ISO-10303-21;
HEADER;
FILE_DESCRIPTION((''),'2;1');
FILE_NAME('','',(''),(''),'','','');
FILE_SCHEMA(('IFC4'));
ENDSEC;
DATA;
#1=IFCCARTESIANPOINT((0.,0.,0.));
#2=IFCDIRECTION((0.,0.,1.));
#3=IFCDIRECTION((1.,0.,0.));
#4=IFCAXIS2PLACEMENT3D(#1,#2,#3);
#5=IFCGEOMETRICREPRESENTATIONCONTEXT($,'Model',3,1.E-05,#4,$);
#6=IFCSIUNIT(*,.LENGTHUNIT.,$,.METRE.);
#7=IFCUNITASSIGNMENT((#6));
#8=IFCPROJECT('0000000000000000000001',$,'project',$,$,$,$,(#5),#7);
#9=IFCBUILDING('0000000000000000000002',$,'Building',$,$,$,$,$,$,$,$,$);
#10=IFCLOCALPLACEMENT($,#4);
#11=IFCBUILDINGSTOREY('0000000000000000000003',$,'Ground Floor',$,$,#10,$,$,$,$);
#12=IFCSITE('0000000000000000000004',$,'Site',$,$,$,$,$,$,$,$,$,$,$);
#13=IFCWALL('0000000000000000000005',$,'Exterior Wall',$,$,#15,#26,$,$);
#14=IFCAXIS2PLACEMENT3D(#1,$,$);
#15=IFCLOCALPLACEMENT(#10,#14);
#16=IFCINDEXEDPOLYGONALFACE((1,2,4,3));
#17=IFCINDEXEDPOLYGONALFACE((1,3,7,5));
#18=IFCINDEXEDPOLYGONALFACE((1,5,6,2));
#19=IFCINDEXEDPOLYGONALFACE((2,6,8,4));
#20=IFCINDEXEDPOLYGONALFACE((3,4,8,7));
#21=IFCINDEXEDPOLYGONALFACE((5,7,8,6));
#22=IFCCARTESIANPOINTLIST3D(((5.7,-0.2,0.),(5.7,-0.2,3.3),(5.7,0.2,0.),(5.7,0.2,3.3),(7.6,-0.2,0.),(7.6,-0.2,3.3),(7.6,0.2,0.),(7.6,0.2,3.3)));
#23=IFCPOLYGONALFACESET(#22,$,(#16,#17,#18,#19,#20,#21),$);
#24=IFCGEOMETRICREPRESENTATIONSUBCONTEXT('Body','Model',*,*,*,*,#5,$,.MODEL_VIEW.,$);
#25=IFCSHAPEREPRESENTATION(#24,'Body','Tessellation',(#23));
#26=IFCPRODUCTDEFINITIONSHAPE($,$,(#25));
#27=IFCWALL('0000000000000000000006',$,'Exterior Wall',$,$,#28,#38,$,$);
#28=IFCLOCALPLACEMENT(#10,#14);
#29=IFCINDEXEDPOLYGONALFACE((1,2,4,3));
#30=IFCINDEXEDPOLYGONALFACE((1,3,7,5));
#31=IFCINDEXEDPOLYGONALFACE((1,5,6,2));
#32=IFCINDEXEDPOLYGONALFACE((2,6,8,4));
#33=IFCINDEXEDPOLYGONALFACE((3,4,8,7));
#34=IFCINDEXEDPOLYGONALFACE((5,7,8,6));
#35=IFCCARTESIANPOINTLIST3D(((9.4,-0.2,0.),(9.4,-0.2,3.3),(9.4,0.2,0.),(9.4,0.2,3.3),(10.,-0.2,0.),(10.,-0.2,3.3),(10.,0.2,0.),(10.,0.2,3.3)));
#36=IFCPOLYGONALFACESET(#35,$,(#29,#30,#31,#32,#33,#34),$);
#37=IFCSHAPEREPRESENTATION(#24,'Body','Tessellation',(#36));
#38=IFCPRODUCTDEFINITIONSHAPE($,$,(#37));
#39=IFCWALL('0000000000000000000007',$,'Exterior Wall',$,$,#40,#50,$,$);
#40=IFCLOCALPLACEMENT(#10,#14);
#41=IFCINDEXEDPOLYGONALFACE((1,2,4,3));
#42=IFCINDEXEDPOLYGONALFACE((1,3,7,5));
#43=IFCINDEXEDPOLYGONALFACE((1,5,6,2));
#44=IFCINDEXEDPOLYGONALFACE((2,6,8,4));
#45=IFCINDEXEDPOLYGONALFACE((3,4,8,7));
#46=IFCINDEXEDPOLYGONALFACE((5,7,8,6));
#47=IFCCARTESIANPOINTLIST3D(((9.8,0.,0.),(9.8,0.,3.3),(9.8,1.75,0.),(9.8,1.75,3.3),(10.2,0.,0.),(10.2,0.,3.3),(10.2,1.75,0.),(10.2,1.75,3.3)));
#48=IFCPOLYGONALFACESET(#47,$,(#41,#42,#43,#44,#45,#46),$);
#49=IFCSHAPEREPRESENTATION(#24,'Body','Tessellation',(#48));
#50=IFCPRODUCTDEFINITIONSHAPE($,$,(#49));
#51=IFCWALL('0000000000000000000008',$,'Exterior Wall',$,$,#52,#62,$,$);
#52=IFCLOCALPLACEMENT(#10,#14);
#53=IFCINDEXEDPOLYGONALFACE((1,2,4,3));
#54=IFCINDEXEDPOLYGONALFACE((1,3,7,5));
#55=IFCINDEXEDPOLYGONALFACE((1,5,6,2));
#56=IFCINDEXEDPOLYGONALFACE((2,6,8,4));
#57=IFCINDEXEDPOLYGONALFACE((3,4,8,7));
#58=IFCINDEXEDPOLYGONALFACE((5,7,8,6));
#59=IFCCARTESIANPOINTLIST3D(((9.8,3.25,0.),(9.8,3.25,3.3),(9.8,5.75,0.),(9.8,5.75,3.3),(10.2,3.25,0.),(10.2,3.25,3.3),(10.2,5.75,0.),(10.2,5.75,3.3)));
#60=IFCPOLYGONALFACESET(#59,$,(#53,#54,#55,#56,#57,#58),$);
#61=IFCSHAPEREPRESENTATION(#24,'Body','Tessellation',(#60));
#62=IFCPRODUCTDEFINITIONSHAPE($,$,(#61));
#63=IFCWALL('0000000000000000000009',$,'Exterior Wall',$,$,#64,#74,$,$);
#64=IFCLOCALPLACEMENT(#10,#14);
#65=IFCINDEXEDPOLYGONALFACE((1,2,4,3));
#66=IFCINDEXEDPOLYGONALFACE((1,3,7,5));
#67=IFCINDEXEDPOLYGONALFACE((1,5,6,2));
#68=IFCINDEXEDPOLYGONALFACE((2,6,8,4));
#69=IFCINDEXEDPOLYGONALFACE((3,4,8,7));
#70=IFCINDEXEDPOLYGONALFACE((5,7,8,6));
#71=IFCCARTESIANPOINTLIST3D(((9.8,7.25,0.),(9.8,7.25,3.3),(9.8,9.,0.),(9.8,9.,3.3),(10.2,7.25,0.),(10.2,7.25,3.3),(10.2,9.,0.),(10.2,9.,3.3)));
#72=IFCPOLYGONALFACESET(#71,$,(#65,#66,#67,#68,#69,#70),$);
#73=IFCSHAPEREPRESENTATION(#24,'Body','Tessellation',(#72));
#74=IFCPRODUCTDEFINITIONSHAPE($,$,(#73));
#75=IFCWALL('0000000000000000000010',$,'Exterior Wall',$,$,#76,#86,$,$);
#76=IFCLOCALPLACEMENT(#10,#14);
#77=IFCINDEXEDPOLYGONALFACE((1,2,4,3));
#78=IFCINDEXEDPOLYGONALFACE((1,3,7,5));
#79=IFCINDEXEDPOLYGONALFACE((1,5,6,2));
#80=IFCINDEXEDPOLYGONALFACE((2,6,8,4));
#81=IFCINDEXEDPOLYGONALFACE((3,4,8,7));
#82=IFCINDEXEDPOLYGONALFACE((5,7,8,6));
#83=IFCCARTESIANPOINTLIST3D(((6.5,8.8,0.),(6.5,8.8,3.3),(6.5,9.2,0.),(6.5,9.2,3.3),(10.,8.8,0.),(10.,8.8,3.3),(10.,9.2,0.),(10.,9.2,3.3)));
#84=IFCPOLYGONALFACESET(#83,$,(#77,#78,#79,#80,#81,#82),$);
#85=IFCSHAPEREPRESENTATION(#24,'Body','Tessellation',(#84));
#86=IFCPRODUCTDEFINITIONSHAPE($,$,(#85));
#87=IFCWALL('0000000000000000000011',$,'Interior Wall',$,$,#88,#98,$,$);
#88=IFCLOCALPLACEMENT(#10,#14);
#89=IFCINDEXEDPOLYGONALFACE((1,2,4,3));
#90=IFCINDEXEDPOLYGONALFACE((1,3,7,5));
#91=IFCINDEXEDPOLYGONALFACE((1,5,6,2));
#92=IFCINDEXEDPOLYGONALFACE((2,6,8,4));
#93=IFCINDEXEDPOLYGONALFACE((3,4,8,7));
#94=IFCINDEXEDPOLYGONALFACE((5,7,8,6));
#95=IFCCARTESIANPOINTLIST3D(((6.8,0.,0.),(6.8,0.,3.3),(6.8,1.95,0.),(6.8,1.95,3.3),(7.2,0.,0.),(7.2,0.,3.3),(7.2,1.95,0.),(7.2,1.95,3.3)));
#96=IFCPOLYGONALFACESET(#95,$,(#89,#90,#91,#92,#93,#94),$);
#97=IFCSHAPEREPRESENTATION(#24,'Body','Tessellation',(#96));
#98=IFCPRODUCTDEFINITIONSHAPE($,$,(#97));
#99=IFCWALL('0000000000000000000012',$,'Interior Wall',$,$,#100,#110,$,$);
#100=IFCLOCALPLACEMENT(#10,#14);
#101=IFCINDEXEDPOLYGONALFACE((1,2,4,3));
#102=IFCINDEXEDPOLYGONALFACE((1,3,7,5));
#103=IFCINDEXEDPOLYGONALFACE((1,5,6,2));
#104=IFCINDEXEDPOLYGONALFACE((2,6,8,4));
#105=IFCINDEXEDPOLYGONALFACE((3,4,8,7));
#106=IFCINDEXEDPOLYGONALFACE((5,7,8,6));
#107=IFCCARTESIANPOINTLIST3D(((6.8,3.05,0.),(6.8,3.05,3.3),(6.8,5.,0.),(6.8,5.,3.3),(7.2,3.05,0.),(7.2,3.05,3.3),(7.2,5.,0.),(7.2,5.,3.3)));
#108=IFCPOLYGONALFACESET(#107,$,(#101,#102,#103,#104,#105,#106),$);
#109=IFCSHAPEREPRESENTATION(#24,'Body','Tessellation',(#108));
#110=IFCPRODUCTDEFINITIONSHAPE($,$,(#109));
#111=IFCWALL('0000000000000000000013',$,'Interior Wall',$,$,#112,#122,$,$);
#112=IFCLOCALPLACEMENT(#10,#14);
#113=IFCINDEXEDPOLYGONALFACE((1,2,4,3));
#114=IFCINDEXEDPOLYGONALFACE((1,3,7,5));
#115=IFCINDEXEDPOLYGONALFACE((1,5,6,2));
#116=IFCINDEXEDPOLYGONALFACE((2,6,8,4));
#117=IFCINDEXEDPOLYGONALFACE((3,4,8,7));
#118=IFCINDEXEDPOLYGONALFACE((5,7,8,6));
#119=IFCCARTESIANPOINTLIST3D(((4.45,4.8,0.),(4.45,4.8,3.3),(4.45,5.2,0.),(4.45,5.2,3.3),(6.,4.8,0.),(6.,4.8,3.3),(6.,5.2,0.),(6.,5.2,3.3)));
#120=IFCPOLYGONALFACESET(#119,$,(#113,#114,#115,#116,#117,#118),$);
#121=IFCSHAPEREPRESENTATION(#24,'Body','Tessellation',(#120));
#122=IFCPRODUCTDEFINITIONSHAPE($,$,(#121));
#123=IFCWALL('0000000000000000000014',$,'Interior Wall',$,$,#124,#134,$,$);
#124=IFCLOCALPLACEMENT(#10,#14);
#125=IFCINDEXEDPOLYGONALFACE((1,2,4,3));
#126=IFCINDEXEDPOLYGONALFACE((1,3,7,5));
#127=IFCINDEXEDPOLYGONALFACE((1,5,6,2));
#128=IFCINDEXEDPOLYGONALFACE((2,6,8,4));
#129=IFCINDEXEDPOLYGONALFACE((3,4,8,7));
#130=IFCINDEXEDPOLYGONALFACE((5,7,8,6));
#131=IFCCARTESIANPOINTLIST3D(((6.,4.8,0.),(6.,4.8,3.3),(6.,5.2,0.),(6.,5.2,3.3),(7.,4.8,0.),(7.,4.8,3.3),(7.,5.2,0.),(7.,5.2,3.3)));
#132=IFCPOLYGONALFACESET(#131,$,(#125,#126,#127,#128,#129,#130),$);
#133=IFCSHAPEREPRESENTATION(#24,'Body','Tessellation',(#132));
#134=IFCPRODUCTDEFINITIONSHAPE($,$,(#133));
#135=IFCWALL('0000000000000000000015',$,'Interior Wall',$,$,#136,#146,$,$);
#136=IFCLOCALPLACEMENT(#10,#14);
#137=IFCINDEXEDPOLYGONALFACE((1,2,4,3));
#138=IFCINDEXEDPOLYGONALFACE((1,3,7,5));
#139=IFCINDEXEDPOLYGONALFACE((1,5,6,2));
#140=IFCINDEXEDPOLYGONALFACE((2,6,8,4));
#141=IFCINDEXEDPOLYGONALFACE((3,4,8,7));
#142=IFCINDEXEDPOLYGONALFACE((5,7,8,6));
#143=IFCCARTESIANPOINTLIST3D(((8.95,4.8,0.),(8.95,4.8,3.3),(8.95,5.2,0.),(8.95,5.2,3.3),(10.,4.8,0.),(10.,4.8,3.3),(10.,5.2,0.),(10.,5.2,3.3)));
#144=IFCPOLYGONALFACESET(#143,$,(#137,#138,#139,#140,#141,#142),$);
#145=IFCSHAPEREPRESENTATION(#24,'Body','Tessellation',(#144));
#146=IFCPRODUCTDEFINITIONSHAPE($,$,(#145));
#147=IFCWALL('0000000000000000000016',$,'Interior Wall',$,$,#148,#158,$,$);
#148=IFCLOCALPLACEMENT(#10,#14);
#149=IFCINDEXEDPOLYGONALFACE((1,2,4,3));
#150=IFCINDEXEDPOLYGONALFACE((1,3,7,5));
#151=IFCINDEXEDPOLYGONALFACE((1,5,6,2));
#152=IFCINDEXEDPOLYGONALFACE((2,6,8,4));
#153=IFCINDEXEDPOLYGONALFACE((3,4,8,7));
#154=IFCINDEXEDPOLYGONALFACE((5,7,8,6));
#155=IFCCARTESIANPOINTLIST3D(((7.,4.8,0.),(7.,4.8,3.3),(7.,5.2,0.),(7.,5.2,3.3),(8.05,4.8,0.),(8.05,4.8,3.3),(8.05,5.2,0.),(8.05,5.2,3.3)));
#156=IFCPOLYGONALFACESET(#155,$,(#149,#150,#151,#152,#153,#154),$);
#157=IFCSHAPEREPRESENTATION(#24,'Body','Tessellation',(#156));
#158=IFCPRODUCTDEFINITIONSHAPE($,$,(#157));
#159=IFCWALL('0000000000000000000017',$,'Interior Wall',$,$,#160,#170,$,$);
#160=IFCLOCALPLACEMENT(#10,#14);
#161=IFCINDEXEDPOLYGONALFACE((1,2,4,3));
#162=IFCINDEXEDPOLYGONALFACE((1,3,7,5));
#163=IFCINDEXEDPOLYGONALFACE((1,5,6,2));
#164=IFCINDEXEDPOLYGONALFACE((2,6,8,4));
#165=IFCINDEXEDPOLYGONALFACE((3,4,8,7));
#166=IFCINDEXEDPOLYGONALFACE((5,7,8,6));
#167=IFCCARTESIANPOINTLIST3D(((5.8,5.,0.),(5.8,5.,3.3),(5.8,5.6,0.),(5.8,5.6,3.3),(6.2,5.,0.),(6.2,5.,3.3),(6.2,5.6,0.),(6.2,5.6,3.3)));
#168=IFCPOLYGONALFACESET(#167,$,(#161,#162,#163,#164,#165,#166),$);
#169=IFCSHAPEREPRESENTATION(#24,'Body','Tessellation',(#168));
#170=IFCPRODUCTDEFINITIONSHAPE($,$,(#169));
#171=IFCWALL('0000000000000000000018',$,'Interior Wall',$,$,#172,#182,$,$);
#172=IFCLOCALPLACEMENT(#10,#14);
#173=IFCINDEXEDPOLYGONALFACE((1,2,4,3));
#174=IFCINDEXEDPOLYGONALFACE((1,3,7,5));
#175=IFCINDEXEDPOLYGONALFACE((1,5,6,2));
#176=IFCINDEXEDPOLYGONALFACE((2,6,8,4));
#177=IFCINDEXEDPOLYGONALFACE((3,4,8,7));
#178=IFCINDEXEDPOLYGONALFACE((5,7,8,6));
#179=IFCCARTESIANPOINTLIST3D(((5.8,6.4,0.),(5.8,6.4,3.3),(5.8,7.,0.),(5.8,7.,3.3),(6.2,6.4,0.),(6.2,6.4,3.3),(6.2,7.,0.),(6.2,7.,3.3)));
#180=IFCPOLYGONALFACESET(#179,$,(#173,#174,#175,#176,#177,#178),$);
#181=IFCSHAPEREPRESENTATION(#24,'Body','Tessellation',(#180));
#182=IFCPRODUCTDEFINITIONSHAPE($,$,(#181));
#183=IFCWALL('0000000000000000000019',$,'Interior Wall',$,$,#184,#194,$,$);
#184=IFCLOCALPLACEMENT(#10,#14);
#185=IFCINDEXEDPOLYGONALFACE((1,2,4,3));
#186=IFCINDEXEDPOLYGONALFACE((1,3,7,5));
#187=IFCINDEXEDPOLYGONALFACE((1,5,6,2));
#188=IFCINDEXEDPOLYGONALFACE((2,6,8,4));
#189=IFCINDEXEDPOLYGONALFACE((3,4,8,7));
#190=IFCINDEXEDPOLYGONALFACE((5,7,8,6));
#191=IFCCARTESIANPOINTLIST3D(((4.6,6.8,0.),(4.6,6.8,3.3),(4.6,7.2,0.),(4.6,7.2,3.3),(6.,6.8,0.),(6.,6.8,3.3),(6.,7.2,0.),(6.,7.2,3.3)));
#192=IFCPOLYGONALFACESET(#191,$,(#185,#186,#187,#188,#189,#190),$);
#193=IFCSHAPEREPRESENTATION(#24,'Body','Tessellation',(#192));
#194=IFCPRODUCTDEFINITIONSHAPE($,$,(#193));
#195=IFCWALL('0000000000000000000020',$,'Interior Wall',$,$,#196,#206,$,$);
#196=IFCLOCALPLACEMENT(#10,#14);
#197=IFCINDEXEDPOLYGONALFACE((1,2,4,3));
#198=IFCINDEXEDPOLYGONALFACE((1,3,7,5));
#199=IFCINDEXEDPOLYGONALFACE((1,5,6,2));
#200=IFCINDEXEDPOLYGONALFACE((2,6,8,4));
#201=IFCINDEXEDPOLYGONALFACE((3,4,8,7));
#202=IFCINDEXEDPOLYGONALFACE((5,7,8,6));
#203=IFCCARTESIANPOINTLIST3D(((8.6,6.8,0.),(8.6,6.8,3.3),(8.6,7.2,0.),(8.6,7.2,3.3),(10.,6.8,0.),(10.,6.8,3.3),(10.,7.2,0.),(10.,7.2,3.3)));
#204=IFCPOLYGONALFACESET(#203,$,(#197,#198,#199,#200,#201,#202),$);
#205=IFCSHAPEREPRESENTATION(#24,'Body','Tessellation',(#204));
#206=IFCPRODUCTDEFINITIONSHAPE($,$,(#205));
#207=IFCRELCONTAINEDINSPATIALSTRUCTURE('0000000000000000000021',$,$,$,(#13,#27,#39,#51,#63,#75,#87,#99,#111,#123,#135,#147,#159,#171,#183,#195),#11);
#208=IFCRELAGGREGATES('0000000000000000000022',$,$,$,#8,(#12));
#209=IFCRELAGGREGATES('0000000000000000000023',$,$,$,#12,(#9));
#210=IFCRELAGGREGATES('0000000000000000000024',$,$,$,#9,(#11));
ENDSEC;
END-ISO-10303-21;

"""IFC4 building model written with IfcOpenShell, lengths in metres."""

from ifc_helpers import new_model, si_unit, frame, origin_with_axes, place, context, subcontext, project, spatial, indexed_curve, outline, extrude, element, save


model = new_model("IFC4")

# Units and contexts
model_context = context("Model", 3, precision=1e-05, world=origin_with_axes())
body_context = subcontext(model_context, "Body", "Model", "MODEL_VIEW")
ifc_project = project(units=[si_unit("LENGTHUNIT", "METRE")], contexts=[model_context])

# Site, building, storey
site = spatial("IfcSite", under=ifc_project, Name="Site")
building = spatial("IfcBuilding", under=site, Name="Building")
storey_placement = place(None, origin_with_axes())
storey = spatial("IfcBuildingStorey", under=building, at=storey_placement, Name="Ground Floor")

# Walls
wall_1_placement = place(storey_placement, frame((5.7, 0.0, 0.0), z_axis=(0.0, 0.0, 1.0), x_axis=(1.0, 0.0, 0.0)))
element("IfcWall", 1, at=wall_1_placement, inside=storey, Name="Exterior Wall", context=body_context, shape_type="SweptSolid", body=[
    extrude(outline(indexed_curve([(0.0, 0.0), (0.0, 0.4), (1.9, 0.4), (1.9, 0.0), (0.0, 0.0)], self_intersect=False)), frame((0.0, -0.2, 0.0), z_axis=(0.0, 0.0, 1.0), x_axis=(1.0, 0.0, 0.0)), (0.0, 0.0, 1.0), 3.3),
])
wall_2_placement = place(storey_placement, frame((9.4, 0.0, 0.0), z_axis=(0.0, 0.0, 1.0), x_axis=(1.0, 0.0, 0.0)))
element("IfcWall", 2, at=wall_2_placement, inside=storey, Name="Exterior Wall", context=body_context, shape_type="SweptSolid", body=[
    extrude(outline(indexed_curve([(0.0, 0.0), (0.0, 0.4), (0.6, 0.4), (0.6, 0.0), (0.0, 0.0)], self_intersect=False)), frame((0.0, -0.2, 0.0), z_axis=(0.0, 0.0, 1.0), x_axis=(1.0, 0.0, 0.0)), (0.0, 0.0, 1.0), 3.3),
])
wall_3_placement = place(storey_placement, frame((10.0, 0.0, 0.0), z_axis=(0.0, 0.0, 1.0), x_axis=(0.0, 1.0, 0.0)))
element("IfcWall", 3, at=wall_3_placement, inside=storey, Name="Exterior Wall", context=body_context, shape_type="SweptSolid", body=[
    extrude(outline(indexed_curve([(0.0, 0.0), (0.0, 0.4), (1.75, 0.4), (1.75, 0.0), (0.0, 0.0)], self_intersect=False)), frame((0.0, -0.2, 0.0), z_axis=(0.0, 0.0, 1.0), x_axis=(1.0, 0.0, 0.0)), (0.0, 0.0, 1.0), 3.3),
])
wall_4_placement = place(storey_placement, frame((10.0, 3.25, 0.0), z_axis=(0.0, 0.0, 1.0), x_axis=(0.0, 1.0, 0.0)))
element("IfcWall", 4, at=wall_4_placement, inside=storey, Name="Exterior Wall", context=body_context, shape_type="SweptSolid", body=[
    extrude(outline(indexed_curve([(0.0, 0.0), (0.0, 0.4), (2.5, 0.4), (2.5, 0.0), (0.0, 0.0)], self_intersect=False)), frame((0.0, -0.2, 0.0), z_axis=(0.0, 0.0, 1.0), x_axis=(1.0, 0.0, 0.0)), (0.0, 0.0, 1.0), 3.3),
])
wall_5_placement = place(storey_placement, frame((10.0, 7.25, 0.0), z_axis=(0.0, 0.0, 1.0), x_axis=(0.0, 1.0, 0.0)))
element("IfcWall", 5, at=wall_5_placement, inside=storey, Name="Exterior Wall", context=body_context, shape_type="SweptSolid", body=[
    extrude(outline(indexed_curve([(0.0, 0.0), (0.0, 0.4), (1.75, 0.4), (1.75, 0.0), (0.0, 0.0)], self_intersect=False)), frame((0.0, -0.2, 0.0), z_axis=(0.0, 0.0, 1.0), x_axis=(1.0, 0.0, 0.0)), (0.0, 0.0, 1.0), 3.3),
])
wall_6_placement = place(storey_placement, frame((10.0, 9.0, 0.0), z_axis=(0.0, 0.0, 1.0), x_axis=(-1.0, 0.0, 0.0)))
element("IfcWall", 6, at=wall_6_placement, inside=storey, Name="Exterior Wall", context=body_context, shape_type="SweptSolid", body=[
    extrude(outline(indexed_curve([(0.0, 0.0), (0.0, 0.4), (3.5, 0.4), (3.5, 0.0), (0.0, 0.0)], self_intersect=False)), frame((0.0, -0.2, 0.0), z_axis=(0.0, 0.0, 1.0), x_axis=(1.0, 0.0, 0.0)), (0.0, 0.0, 1.0), 3.3),
])
wall_7_placement = place(storey_placement, frame((7.0, 0.0, 0.0), z_axis=(0.0, 0.0, 1.0), x_axis=(0.0, 1.0, 0.0)))
element("IfcWall", 7, at=wall_7_placement, inside=storey, Name="Interior Wall", context=body_context, shape_type="SweptSolid", body=[
    extrude(outline(indexed_curve([(0.0, 0.0), (0.0, 0.4), (1.95, 0.4), (1.95, 0.0), (0.0, 0.0)], self_intersect=False)), frame((0.0, -0.2, 0.0), z_axis=(0.0, 0.0, 1.0), x_axis=(1.0, 0.0, 0.0)), (0.0, 0.0, 1.0), 3.3),
])
wall_8_placement = place(storey_placement, frame((7.0, 3.05, 0.0), z_axis=(0.0, 0.0, 1.0), x_axis=(0.0, 1.0, 0.0)))
element("IfcWall", 8, at=wall_8_placement, inside=storey, Name="Interior Wall", context=body_context, shape_type="SweptSolid", body=[
    extrude(outline(indexed_curve([(0.0, 0.0), (0.0, 0.4), (1.95, 0.4), (1.95, 0.0), (0.0, 0.0)], self_intersect=False)), frame((0.0, -0.2, 0.0), z_axis=(0.0, 0.0, 1.0), x_axis=(1.0, 0.0, 0.0)), (0.0, 0.0, 1.0), 3.3),
])
wall_9_placement = place(storey_placement, frame((6.0, 5.0, 0.0), z_axis=(0.0, 0.0, 1.0), x_axis=(-1.0, 0.0, 0.0)))
element("IfcWall", 9, at=wall_9_placement, inside=storey, Name="Interior Wall", context=body_context, shape_type="SweptSolid", body=[
    extrude(outline(indexed_curve([(0.0, 0.0), (0.0, 0.4), (1.55, 0.4), (1.55, 0.0), (0.0, 0.0)], self_intersect=False)), frame((0.0, -0.2, 0.0), z_axis=(0.0, 0.0, 1.0), x_axis=(1.0, 0.0, 0.0)), (0.0, 0.0, 1.0), 3.3),
])
wall_10_placement = place(storey_placement, frame((7.0, 5.0, 0.0), z_axis=(0.0, 0.0, 1.0), x_axis=(-1.0, 0.0, 0.0)))
element("IfcWall", 10, at=wall_10_placement, inside=storey, Name="Interior Wall", context=body_context, shape_type="SweptSolid", body=[
    extrude(outline(indexed_curve([(0.0, 0.0), (0.0, 0.4), (1.0, 0.4), (1.0, 0.0), (0.0, 0.0)], self_intersect=False)), frame((0.0, -0.2, 0.0), z_axis=(0.0, 0.0, 1.0), x_axis=(1.0, 0.0, 0.0)), (0.0, 0.0, 1.0), 3.3),
])
for number, where, z_axis, x_axis, name in (
    (11, (10.0, 5.0, 0.0), (0.0, 0.0, 1.0), (-1.0, 0.0, 0.0), "Interior Wall"),
    (12, (8.05, 5.0, 0.0), (0.0, 0.0, 1.0), (-1.0, 0.0, 0.0), "Interior Wall"),
):
    element("IfcWall", number, at=place(storey_placement, frame(where, z_axis=z_axis, x_axis=x_axis)), inside=storey, Name=name, context=body_context, shape_type="SweptSolid", body=[
        extrude(outline(indexed_curve([(0.0, 0.0), (0.0, 0.4), (1.05, 0.4), (1.05, 0.0), (0.0, 0.0)], self_intersect=False)), frame((0.0, -0.2, 0.0), z_axis=(0.0, 0.0, 1.0), x_axis=(1.0, 0.0, 0.0)), (0.0, 0.0, 1.0), 3.3),
    ])
for number, where, z_axis, x_axis, name in (
    (13, (6.0, 5.0, 0.0), (0.0, 0.0, 1.0), (0.0, 1.0, 0.0), "Interior Wall"),
    (14, (6.0, 6.4, 0.0), (0.0, 0.0, 1.0), (0.0, 1.0, 0.0), "Interior Wall"),
):
    element("IfcWall", number, at=place(storey_placement, frame(where, z_axis=z_axis, x_axis=x_axis)), inside=storey, Name=name, context=body_context, shape_type="SweptSolid", body=[
        extrude(outline(indexed_curve([(0.0, 0.0), (0.0, 0.4), (0.6, 0.4), (0.6, 0.0), (0.0, 0.0)], self_intersect=False)), frame((0.0, -0.2, 0.0), z_axis=(0.0, 0.0, 1.0), x_axis=(1.0, 0.0, 0.0)), (0.0, 0.0, 1.0), 3.3),
    ])
for number, where, z_axis, x_axis, name in (
    (15, (6.0, 7.0, 0.0), (0.0, 0.0, 1.0), (-1.0, 0.0, 0.0), "Interior Wall"),
    (16, (10.0, 7.0, 0.0), (0.0, 0.0, 1.0), (-1.0, 0.0, 0.0), "Interior Wall"),
):
    element("IfcWall", number, at=place(storey_placement, frame(where, z_axis=z_axis, x_axis=x_axis)), inside=storey, Name=name, context=body_context, shape_type="SweptSolid", body=[
        extrude(outline(indexed_curve([(0.0, 0.0), (0.0, 0.4), (1.4, 0.4), (1.4, 0.0), (0.0, 0.0)], self_intersect=False)), frame((0.0, -0.2, 0.0), z_axis=(0.0, 0.0, 1.0), x_axis=(1.0, 0.0, 0.0)), (0.0, 0.0, 1.0), 3.3),
    ])

save(model, "model.ifc")
